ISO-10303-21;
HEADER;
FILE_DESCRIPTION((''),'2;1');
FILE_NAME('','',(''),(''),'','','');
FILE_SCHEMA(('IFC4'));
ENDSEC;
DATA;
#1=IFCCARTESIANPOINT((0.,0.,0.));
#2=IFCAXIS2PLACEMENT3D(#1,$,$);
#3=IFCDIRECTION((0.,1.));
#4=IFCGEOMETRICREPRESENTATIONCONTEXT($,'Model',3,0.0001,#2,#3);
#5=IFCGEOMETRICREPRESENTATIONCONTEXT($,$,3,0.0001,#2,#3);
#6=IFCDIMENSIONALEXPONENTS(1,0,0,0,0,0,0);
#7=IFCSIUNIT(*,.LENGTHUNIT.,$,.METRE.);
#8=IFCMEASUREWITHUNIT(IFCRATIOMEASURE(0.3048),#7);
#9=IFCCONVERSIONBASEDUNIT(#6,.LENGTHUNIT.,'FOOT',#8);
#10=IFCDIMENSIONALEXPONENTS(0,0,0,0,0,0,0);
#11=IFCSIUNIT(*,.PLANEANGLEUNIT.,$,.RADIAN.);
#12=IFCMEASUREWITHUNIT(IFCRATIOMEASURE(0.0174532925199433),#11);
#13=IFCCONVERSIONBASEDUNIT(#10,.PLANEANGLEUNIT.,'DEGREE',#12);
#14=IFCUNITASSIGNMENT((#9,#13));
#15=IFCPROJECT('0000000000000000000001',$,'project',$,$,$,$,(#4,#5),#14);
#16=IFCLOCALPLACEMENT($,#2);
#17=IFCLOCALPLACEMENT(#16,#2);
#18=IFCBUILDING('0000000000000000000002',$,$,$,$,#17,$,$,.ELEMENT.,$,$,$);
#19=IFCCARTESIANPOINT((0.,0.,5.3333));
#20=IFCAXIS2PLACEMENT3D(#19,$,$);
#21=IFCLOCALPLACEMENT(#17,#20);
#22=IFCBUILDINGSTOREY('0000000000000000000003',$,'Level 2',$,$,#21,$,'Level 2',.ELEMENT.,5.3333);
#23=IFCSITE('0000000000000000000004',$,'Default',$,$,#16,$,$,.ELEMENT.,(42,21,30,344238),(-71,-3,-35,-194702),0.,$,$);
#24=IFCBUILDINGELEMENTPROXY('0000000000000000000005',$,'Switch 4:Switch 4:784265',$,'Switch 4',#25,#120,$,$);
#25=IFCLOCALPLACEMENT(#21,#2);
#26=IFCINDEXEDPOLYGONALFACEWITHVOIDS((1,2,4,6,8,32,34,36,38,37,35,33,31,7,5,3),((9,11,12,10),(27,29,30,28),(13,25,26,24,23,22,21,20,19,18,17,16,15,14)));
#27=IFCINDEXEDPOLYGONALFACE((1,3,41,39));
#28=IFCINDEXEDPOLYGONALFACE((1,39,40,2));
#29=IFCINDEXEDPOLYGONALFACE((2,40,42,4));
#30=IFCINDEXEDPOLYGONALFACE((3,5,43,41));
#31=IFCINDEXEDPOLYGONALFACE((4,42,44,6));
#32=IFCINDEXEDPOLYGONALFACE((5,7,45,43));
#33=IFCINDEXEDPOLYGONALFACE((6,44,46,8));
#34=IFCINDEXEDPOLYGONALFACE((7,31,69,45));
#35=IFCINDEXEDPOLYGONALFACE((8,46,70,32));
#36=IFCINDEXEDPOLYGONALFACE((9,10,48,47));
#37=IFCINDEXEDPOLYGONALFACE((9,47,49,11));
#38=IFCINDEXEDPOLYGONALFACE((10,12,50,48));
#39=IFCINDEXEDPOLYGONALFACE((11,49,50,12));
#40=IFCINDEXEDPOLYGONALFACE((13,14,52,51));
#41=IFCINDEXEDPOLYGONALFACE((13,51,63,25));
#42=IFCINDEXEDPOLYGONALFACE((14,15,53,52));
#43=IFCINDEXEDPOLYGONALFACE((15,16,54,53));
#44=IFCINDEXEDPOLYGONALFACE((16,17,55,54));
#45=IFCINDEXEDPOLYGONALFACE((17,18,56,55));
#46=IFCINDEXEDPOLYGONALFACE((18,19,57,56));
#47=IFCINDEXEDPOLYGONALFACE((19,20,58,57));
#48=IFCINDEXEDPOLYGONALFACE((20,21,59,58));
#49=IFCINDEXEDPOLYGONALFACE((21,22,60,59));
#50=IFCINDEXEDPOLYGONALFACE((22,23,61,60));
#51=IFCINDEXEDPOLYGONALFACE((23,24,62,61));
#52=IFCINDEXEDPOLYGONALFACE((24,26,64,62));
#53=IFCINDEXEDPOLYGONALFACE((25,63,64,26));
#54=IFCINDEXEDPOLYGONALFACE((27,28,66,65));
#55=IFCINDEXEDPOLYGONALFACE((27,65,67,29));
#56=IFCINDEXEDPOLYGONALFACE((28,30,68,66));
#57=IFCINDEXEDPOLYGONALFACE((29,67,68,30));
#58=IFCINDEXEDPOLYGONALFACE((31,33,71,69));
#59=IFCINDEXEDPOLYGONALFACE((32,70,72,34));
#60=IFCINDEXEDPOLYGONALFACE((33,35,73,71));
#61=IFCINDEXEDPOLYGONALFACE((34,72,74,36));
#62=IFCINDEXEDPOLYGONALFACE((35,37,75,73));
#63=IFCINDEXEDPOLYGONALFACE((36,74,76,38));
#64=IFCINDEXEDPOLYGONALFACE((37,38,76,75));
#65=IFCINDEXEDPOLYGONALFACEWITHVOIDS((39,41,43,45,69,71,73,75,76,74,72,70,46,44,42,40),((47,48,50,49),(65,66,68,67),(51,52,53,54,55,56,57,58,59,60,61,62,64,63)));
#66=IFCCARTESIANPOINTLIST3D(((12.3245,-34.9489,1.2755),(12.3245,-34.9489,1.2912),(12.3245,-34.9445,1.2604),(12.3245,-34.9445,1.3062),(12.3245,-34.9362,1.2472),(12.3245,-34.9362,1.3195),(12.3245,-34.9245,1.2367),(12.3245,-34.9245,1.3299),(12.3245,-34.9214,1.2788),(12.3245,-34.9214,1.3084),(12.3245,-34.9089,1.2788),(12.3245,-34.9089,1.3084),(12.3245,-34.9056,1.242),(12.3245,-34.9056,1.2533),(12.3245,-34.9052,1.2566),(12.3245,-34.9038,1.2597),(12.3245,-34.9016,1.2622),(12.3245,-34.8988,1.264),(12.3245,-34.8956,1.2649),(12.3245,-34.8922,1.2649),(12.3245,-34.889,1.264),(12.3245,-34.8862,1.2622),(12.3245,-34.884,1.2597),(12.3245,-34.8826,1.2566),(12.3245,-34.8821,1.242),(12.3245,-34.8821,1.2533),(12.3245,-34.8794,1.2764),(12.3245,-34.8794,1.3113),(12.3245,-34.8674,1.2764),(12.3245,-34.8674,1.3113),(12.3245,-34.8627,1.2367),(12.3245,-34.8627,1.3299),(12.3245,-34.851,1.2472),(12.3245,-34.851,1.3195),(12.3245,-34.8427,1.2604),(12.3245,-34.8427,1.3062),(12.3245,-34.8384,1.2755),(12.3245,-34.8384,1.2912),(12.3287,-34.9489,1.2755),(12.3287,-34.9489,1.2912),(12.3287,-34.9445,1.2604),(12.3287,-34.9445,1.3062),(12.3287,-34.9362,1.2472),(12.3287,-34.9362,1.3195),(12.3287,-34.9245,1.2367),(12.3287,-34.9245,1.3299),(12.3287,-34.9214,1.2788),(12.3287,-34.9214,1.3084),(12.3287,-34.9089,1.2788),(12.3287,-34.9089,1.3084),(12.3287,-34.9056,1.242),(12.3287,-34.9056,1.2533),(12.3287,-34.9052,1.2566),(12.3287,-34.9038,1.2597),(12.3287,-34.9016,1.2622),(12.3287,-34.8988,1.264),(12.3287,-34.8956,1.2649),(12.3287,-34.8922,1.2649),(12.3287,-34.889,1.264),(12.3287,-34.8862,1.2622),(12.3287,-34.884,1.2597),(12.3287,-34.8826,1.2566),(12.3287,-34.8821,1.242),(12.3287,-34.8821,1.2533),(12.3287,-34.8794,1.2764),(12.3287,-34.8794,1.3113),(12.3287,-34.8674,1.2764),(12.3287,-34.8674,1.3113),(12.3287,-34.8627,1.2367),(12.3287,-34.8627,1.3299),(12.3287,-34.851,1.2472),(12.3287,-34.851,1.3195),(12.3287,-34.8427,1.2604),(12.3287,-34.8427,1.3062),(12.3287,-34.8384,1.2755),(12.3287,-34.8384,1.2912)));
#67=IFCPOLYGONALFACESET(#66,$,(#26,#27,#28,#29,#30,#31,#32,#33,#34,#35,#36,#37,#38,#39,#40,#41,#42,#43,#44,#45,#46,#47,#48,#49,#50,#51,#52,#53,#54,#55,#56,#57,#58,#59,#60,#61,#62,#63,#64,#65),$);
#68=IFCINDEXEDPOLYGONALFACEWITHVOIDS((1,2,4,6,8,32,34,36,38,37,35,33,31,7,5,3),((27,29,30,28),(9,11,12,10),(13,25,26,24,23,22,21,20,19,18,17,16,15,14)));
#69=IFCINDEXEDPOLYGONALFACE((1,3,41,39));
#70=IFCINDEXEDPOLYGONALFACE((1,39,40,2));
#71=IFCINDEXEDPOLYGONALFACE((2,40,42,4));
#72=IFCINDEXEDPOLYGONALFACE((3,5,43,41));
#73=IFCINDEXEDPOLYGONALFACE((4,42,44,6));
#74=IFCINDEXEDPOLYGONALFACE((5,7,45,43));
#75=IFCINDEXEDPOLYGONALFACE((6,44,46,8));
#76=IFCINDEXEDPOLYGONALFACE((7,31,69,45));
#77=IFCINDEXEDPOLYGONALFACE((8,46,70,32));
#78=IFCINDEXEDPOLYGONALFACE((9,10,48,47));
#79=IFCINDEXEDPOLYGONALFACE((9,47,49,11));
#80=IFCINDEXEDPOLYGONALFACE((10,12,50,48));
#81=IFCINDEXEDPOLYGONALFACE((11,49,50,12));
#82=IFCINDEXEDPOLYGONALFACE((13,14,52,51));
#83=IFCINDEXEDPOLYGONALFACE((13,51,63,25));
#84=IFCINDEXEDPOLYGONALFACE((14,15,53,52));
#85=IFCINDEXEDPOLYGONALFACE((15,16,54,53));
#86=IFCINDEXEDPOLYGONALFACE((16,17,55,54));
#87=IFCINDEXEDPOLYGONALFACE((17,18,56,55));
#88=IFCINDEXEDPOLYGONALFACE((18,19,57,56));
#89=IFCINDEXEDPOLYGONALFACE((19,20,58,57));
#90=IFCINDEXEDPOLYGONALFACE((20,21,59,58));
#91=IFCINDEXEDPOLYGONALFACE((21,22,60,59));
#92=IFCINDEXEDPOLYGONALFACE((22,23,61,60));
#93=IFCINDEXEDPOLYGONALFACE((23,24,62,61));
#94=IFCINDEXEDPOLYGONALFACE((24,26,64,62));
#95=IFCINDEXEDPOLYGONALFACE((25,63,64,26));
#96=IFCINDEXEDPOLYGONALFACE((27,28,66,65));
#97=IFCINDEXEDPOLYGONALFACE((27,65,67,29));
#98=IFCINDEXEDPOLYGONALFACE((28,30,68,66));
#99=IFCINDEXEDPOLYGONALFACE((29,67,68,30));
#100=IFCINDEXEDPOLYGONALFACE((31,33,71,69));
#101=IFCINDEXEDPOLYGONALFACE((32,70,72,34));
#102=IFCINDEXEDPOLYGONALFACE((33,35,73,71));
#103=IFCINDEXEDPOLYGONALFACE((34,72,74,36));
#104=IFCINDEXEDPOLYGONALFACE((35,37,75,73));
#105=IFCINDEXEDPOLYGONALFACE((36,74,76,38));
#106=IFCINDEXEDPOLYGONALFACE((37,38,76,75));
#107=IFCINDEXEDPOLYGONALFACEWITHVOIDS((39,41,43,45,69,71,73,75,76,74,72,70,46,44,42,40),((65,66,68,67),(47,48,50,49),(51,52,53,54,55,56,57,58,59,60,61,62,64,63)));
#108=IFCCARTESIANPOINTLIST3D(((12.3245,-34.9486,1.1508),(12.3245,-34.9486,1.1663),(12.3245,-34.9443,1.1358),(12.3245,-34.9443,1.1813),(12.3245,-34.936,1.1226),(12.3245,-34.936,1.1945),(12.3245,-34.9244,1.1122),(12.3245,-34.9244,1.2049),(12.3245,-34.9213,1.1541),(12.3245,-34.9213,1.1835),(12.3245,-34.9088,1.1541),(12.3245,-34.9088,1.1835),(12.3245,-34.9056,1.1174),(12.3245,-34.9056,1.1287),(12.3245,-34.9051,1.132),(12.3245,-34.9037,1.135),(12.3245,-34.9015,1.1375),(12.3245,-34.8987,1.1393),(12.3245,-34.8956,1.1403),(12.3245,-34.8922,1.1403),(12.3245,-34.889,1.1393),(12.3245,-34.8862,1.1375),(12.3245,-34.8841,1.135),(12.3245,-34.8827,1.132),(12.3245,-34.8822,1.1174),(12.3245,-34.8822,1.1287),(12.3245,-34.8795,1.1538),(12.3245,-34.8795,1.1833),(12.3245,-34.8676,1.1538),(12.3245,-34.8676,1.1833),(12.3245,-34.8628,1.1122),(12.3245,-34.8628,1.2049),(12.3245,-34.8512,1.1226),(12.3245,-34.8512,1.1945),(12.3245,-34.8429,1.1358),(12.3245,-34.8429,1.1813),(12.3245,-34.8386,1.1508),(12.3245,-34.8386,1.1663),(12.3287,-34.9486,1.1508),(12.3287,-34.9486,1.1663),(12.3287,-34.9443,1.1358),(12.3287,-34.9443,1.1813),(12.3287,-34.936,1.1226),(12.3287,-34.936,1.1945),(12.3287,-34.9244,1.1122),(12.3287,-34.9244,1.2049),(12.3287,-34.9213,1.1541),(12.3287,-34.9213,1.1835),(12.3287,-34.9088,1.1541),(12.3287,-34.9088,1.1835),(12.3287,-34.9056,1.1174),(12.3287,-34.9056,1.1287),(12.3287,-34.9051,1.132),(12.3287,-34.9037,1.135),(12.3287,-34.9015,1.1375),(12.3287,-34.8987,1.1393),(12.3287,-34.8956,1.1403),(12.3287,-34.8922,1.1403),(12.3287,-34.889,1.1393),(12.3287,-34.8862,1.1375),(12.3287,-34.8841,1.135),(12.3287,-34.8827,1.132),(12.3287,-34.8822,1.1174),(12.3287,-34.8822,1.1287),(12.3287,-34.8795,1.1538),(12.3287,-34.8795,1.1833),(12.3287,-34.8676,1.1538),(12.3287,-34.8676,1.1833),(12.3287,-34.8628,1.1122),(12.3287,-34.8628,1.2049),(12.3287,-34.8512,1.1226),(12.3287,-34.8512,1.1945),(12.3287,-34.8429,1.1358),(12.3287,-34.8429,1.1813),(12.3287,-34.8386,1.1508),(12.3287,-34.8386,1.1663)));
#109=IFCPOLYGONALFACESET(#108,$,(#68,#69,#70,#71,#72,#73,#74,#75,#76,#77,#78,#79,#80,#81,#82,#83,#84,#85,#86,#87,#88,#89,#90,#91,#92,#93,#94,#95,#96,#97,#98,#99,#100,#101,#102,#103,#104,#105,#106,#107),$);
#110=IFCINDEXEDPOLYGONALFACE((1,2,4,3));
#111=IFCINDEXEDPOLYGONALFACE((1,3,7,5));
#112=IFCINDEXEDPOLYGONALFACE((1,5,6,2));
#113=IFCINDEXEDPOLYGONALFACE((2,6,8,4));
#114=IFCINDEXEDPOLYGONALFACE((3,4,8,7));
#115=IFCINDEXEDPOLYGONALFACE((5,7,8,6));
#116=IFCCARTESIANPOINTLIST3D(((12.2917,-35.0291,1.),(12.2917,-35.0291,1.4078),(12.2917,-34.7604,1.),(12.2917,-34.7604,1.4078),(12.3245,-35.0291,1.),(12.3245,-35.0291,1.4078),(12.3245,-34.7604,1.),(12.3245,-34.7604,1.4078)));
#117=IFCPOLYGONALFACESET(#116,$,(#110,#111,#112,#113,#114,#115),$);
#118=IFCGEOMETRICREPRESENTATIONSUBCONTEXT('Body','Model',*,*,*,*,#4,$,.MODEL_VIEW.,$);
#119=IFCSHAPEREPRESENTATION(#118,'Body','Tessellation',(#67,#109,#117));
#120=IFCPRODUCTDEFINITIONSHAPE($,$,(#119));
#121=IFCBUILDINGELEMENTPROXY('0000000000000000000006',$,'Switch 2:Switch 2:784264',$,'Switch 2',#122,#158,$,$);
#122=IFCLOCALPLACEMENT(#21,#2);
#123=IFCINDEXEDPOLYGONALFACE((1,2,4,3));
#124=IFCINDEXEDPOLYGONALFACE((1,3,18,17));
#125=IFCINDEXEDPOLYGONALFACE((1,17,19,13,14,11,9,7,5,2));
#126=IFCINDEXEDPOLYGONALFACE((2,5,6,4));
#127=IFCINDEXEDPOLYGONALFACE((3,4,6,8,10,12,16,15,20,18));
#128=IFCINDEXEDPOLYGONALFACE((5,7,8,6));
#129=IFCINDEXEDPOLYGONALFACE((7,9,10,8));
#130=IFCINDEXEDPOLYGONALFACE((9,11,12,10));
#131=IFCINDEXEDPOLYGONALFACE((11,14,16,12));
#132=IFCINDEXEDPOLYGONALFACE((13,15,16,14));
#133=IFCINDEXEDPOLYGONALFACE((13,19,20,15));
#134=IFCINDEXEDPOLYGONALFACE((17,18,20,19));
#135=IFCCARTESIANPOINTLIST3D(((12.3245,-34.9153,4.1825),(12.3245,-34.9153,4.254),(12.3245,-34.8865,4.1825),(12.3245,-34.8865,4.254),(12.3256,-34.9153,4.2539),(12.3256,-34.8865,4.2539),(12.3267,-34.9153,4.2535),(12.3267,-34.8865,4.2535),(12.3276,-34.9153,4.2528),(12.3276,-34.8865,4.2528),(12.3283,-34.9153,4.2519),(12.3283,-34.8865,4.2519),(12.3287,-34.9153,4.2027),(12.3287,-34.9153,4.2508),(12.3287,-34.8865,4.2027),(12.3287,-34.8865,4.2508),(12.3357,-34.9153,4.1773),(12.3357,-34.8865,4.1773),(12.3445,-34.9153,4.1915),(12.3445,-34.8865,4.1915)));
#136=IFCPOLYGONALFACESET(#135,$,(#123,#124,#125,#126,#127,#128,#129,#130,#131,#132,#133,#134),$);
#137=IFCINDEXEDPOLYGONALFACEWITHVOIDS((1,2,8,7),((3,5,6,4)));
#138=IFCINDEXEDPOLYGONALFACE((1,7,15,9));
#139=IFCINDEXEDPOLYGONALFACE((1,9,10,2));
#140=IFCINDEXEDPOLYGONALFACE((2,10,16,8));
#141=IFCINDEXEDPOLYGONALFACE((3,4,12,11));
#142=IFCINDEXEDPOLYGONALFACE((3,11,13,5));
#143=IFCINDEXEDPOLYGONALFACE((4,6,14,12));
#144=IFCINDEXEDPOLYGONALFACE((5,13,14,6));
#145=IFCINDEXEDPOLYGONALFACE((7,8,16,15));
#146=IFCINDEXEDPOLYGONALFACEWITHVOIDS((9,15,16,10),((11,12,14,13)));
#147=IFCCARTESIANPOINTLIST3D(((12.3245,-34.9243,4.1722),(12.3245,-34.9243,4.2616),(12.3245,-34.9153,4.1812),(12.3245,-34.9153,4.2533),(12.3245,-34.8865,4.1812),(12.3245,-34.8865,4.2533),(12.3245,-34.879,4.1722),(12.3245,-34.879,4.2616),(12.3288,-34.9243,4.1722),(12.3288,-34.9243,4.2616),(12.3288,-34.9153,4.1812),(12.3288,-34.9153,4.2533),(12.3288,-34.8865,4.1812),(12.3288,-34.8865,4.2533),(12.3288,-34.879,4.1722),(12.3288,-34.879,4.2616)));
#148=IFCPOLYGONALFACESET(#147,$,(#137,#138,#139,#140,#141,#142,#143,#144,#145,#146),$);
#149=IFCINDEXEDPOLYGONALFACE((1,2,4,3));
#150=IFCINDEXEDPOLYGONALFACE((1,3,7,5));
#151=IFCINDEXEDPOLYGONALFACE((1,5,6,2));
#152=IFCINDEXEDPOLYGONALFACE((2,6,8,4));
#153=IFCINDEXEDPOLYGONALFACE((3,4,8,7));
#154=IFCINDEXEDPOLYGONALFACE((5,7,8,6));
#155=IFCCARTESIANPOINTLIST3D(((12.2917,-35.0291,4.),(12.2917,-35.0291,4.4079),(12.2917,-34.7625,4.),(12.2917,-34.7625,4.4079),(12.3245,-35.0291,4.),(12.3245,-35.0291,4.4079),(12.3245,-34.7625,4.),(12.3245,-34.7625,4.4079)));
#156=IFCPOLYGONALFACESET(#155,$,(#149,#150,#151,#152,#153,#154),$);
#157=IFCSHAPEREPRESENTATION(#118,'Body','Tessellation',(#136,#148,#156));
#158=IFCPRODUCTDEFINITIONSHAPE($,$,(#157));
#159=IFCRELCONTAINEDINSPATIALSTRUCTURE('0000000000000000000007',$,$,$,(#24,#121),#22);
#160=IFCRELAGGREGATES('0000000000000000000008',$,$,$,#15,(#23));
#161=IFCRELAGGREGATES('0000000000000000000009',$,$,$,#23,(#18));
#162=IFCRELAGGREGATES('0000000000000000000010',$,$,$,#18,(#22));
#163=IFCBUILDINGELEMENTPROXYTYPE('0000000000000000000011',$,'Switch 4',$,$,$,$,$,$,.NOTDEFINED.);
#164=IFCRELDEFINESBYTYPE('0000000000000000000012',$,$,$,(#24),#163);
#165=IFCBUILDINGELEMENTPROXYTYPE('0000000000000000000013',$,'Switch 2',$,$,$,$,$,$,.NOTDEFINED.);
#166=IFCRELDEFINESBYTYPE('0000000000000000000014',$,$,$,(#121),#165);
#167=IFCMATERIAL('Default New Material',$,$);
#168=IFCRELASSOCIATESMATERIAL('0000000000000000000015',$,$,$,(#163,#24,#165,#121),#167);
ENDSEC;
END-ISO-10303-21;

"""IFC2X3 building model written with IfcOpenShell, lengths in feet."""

from ifc_helpers import new_model, entity, si_unit, converted_unit, direction, frame, frame_2d, origin, origin_2d_with_axis, place, context, subcontext, project, spatial, polyline, circle_curve, parameter, trimmed, segment, composite_curve, rectangle, outline, extrude, source, transform, mapped, material, type_object, type_shapes, element, save


model = new_model("IFC2X3")

# Units and contexts
model_context = context("Model", 3, precision=0.0001, world=origin(), true_north=direction((0.0, 1.0)))
context_of_model = context(None, 3, precision=0.0001, world=origin(), true_north=direction((0.0, 1.0)))
body_context = subcontext(model_context, "Body", "Model", "MODEL_VIEW")
ifc_project = project(units=[converted_unit("LENGTHUNIT", "FOOT", entity("IfcRatioMeasure", 0.3048), si_unit("LENGTHUNIT", "METRE"), dimensions=[1, 0, 0, 0, 0, 0, 0]), converted_unit("PLANEANGLEUNIT", "DEGREE", entity("IfcRatioMeasure", 0.0174532925199433), si_unit("PLANEANGLEUNIT", "RADIAN"), dimensions=[0, 0, 0, 0, 0, 0, 0])], contexts=[model_context, context_of_model])

# Site, building, storey
site_placement = place(None, origin())
site = spatial("IfcSite", under=ifc_project, at=site_placement, Name="Default", CompositionType="ELEMENT", RefLatitude=(42, 21, 30, 344238), RefLongitude=(-71, -3, -35, -194702), RefElevation=0.0)
building_placement = place(site_placement, origin())
building = spatial("IfcBuilding", under=site, at=building_placement, CompositionType="ELEMENT")
storey_placement = place(building_placement, frame((0.0, 0.0, 5.3333)))
storey = spatial("IfcBuildingStorey", under=building, at=storey_placement, Name="Level 2", LongName="Level 2", CompositionType="ELEMENT", Elevation=5.3333)

# Shared definitions
ifc_material_1 = material(Name="Default New Material")

# Building element proxies
building_element_proxy_type_1 = type_object("IfcBuildingElementProxyType", Name="Switch 4", PredefinedType="NOTDEFINED", material=ifc_material_1)
shared_shape_1 = source(origin(), body_context, "Body", "SweptSolid", [
    extrude(outline(composite_curve([segment(polyline([(-0.0309, -0.0466), (0.0309, -0.0466)]), True, "CONTINUOUS"), segment(trimmed(circle_curve(frame_2d((-0.0003, 0.0), x_axis=(-1.0, 0.0)), 0.0561), [parameter(123.794741)], [parameter(236.205259)], True, "PARAMETER"), True, "CONTINUOUS"), segment(polyline([(0.0309, 0.0466), (-0.0309, 0.0466)]), True, "CONTINUOUS"), segment(trimmed(circle_curve(frame_2d((0.0003, 0.0), x_axis=(1.0, 0.0)), 0.0561), [parameter(123.794741)], [parameter(236.205259)], True, "PARAMETER"), True, "CONTINUOUS")], self_intersect=False), holes=[polyline([(0.0142, 0.0279), (0.0262, 0.0279), (0.0262, -0.0069), (0.0142, -0.0069), (0.0142, 0.0279)]), polyline([(-0.0153, 0.025), (-0.0153, -0.0045), (-0.0278, -0.0045), (-0.0278, 0.025), (-0.0153, 0.025)]), composite_curve([segment(polyline([(-0.012, -0.0413), (-0.012, -0.03)]), True, "CONTINUOUS"), segment(trimmed(circle_curve(frame_2d((-0.0003, -0.03), x_axis=(-1.0, 0.0)), 0.0117), [parameter(180.0)], [parameter(0.0)], True, "PARAMETER"), False, "CONTINUOUS"), segment(polyline([(0.0115, -0.03), (0.0115, -0.0413)]), True, "CONTINUOUS"), segment(polyline([(0.0115, -0.0413), (-0.012, -0.0413)]), True, "CONTINUOUS")], self_intersect=False)]), frame((-0.0011, 0.0328, 0.2833), z_axis=(0.0, 1.0, 0.0), x_axis=(-1.0, 0.0, 0.0)), (0.0, 0.0, 1.0), 0.0042),
    extrude(outline(composite_curve([segment(polyline([(-0.0308, -0.0464), (0.0308, -0.0464)]), True, "CONTINUOUS"), segment(trimmed(circle_curve(frame_2d((-0.0003, 0.0), x_axis=(-1.0, 0.0)), 0.0558), [parameter(123.794741)], [parameter(236.205259)], True, "PARAMETER"), True, "CONTINUOUS"), segment(polyline([(0.0308, 0.0464), (-0.0308, 0.0464)]), True, "CONTINUOUS"), segment(trimmed(circle_curve(frame_2d((0.0003, 0.0), x_axis=(1.0, 0.0)), 0.0558), [parameter(123.794741)], [parameter(236.205259)], True, "PARAMETER"), True, "CONTINUOUS")], self_intersect=False), holes=[polyline([(0.0141, 0.0247), (0.026, 0.0247), (0.026, -0.0047), (0.0141, -0.0047), (0.0141, 0.0247)]), polyline([(-0.0152, 0.0249), (-0.0152, -0.0045), (-0.0277, -0.0045), (-0.0277, 0.0249), (-0.0152, 0.0249)]), composite_curve([segment(polyline([(-0.012, -0.0411), (-0.012, -0.0299)]), True, "CONTINUOUS"), segment(trimmed(circle_curve(frame_2d((-0.0003, -0.0299), x_axis=(-1.0, 0.0)), 0.0117), [parameter(180.0)], [parameter(0.0)], True, "PARAMETER"), False, "CONTINUOUS"), segment(polyline([(0.0114, -0.0299), (0.0114, -0.0411)]), True, "CONTINUOUS"), segment(polyline([(0.0114, -0.0411), (-0.012, -0.0411)]), True, "CONTINUOUS")], self_intersect=False)]), frame((-0.0011, 0.0328, 0.1586), z_axis=(0.0, 1.0, 0.0), x_axis=(-1.0, 0.0, 0.0)), (0.0, 0.0, 1.0), 0.0042),
    extrude(rectangle(XDim=0.0328, YDim=0.2687, at=origin_2d_with_axis()), frame((0.0, 0.0164, 0.0), z_axis=(0.0, 0.0, 1.0), x_axis=(0.0, -1.0, 0.0)), (0.0, 0.0, 1.0), 0.4078),
])
type_shapes(building_element_proxy_type_1, [shared_shape_1])
proxy_1_placement = place(storey_placement, frame((12.2917, -34.8947, 1.0), z_axis=(0.0, 0.0, 1.0), x_axis=(0.0, -1.0, 0.0)))
element("IfcBuildingElementProxy", 1, at=proxy_1_placement, inside=storey, type_object=building_element_proxy_type_1, material=ifc_material_1, Name="Switch 4:Switch 4:784265", ObjectType="Switch 4", context=body_context, shape_type="MappedRepresentation", body=[
    mapped(shared_shape_1, transform((0.0, 0.0, 0.0), scale=1.0)),
])
building_element_proxy_type_2 = type_object("IfcBuildingElementProxyType", Name="Switch 2", PredefinedType="NOTDEFINED", material=ifc_material_1)
shared_shape_2 = source(origin(), body_context, "Body", "SweptSolid", [
    extrude(outline(composite_curve([segment(polyline([(-0.0252, -0.0211), (-0.0084, -0.0211)]), True, "CONTINUOUS"), segment(polyline([(-0.0084, -0.0211), (-0.0073, -0.0017)]), True, "CONTINUOUS"), segment(polyline([(-0.0073, -0.0017), (0.0336, 0.0237)]), True, "CONTINUOUS"), segment(trimmed(circle_curve(frame_2d((0.0308, 0.0266), x_axis=(0.848706, 0.528865)), 0.004), [parameter(281.689503)], [parameter(4.471238)], True, "PARAMETER"), True, "CONTINUOUS"), segment(polyline([(0.034, 0.029), (-0.0267, -0.0088)]), True, "CONTINUOUS"), segment(polyline([(-0.0267, -0.0088), (-0.0252, -0.0211)]), True, "CONTINUOUS")], self_intersect=False)), frame((-0.0093, 0.0394, 0.2098), z_axis=(1.0, 0.0, 0.0), x_axis=(0.0, 0.528865, 0.848706)), (0.0, 0.0, 1.0), 0.0287),
    extrude(outline(polyline([(-0.0447, -0.0227), (0.0447, -0.0227), (0.0447, 0.0227), (-0.0447, 0.0227), (-0.0447, -0.0227)]), holes=[polyline([(-0.0364, -0.0136), (-0.0364, 0.0151), (0.0357, 0.0151), (0.0357, -0.0136), (-0.0364, -0.0136)])]), frame((0.0058, 0.0329, 0.2169), z_axis=(0.0, 1.0, 0.0), x_axis=(0.0, 0.0, -1.0)), (0.0, 0.0, 1.0), 0.0042),
    extrude(rectangle(XDim=0.0329, YDim=0.2666, at=origin_2d_with_axis()), frame((-0.0001, 0.0164, 0.0), z_axis=(0.0, 0.0, 1.0), x_axis=(0.0, -1.0, 0.0)), (0.0, 0.0, 1.0), 0.4079),
])
type_shapes(building_element_proxy_type_2, [shared_shape_2])
proxy_2_placement = place(storey_placement, frame((12.2917, -34.8958, 4.0), z_axis=(0.0, 0.0, 1.0), x_axis=(0.0, -1.0, 0.0)))
element("IfcBuildingElementProxy", 2, at=proxy_2_placement, inside=storey, type_object=building_element_proxy_type_2, material=ifc_material_1, Name="Switch 2:Switch 2:784264", ObjectType="Switch 2", context=body_context, shape_type="MappedRepresentation", body=[
    mapped(shared_shape_2, transform((0.0, 0.0, 0.0), scale=1.0)),
])

save(model, "model.ifc")
